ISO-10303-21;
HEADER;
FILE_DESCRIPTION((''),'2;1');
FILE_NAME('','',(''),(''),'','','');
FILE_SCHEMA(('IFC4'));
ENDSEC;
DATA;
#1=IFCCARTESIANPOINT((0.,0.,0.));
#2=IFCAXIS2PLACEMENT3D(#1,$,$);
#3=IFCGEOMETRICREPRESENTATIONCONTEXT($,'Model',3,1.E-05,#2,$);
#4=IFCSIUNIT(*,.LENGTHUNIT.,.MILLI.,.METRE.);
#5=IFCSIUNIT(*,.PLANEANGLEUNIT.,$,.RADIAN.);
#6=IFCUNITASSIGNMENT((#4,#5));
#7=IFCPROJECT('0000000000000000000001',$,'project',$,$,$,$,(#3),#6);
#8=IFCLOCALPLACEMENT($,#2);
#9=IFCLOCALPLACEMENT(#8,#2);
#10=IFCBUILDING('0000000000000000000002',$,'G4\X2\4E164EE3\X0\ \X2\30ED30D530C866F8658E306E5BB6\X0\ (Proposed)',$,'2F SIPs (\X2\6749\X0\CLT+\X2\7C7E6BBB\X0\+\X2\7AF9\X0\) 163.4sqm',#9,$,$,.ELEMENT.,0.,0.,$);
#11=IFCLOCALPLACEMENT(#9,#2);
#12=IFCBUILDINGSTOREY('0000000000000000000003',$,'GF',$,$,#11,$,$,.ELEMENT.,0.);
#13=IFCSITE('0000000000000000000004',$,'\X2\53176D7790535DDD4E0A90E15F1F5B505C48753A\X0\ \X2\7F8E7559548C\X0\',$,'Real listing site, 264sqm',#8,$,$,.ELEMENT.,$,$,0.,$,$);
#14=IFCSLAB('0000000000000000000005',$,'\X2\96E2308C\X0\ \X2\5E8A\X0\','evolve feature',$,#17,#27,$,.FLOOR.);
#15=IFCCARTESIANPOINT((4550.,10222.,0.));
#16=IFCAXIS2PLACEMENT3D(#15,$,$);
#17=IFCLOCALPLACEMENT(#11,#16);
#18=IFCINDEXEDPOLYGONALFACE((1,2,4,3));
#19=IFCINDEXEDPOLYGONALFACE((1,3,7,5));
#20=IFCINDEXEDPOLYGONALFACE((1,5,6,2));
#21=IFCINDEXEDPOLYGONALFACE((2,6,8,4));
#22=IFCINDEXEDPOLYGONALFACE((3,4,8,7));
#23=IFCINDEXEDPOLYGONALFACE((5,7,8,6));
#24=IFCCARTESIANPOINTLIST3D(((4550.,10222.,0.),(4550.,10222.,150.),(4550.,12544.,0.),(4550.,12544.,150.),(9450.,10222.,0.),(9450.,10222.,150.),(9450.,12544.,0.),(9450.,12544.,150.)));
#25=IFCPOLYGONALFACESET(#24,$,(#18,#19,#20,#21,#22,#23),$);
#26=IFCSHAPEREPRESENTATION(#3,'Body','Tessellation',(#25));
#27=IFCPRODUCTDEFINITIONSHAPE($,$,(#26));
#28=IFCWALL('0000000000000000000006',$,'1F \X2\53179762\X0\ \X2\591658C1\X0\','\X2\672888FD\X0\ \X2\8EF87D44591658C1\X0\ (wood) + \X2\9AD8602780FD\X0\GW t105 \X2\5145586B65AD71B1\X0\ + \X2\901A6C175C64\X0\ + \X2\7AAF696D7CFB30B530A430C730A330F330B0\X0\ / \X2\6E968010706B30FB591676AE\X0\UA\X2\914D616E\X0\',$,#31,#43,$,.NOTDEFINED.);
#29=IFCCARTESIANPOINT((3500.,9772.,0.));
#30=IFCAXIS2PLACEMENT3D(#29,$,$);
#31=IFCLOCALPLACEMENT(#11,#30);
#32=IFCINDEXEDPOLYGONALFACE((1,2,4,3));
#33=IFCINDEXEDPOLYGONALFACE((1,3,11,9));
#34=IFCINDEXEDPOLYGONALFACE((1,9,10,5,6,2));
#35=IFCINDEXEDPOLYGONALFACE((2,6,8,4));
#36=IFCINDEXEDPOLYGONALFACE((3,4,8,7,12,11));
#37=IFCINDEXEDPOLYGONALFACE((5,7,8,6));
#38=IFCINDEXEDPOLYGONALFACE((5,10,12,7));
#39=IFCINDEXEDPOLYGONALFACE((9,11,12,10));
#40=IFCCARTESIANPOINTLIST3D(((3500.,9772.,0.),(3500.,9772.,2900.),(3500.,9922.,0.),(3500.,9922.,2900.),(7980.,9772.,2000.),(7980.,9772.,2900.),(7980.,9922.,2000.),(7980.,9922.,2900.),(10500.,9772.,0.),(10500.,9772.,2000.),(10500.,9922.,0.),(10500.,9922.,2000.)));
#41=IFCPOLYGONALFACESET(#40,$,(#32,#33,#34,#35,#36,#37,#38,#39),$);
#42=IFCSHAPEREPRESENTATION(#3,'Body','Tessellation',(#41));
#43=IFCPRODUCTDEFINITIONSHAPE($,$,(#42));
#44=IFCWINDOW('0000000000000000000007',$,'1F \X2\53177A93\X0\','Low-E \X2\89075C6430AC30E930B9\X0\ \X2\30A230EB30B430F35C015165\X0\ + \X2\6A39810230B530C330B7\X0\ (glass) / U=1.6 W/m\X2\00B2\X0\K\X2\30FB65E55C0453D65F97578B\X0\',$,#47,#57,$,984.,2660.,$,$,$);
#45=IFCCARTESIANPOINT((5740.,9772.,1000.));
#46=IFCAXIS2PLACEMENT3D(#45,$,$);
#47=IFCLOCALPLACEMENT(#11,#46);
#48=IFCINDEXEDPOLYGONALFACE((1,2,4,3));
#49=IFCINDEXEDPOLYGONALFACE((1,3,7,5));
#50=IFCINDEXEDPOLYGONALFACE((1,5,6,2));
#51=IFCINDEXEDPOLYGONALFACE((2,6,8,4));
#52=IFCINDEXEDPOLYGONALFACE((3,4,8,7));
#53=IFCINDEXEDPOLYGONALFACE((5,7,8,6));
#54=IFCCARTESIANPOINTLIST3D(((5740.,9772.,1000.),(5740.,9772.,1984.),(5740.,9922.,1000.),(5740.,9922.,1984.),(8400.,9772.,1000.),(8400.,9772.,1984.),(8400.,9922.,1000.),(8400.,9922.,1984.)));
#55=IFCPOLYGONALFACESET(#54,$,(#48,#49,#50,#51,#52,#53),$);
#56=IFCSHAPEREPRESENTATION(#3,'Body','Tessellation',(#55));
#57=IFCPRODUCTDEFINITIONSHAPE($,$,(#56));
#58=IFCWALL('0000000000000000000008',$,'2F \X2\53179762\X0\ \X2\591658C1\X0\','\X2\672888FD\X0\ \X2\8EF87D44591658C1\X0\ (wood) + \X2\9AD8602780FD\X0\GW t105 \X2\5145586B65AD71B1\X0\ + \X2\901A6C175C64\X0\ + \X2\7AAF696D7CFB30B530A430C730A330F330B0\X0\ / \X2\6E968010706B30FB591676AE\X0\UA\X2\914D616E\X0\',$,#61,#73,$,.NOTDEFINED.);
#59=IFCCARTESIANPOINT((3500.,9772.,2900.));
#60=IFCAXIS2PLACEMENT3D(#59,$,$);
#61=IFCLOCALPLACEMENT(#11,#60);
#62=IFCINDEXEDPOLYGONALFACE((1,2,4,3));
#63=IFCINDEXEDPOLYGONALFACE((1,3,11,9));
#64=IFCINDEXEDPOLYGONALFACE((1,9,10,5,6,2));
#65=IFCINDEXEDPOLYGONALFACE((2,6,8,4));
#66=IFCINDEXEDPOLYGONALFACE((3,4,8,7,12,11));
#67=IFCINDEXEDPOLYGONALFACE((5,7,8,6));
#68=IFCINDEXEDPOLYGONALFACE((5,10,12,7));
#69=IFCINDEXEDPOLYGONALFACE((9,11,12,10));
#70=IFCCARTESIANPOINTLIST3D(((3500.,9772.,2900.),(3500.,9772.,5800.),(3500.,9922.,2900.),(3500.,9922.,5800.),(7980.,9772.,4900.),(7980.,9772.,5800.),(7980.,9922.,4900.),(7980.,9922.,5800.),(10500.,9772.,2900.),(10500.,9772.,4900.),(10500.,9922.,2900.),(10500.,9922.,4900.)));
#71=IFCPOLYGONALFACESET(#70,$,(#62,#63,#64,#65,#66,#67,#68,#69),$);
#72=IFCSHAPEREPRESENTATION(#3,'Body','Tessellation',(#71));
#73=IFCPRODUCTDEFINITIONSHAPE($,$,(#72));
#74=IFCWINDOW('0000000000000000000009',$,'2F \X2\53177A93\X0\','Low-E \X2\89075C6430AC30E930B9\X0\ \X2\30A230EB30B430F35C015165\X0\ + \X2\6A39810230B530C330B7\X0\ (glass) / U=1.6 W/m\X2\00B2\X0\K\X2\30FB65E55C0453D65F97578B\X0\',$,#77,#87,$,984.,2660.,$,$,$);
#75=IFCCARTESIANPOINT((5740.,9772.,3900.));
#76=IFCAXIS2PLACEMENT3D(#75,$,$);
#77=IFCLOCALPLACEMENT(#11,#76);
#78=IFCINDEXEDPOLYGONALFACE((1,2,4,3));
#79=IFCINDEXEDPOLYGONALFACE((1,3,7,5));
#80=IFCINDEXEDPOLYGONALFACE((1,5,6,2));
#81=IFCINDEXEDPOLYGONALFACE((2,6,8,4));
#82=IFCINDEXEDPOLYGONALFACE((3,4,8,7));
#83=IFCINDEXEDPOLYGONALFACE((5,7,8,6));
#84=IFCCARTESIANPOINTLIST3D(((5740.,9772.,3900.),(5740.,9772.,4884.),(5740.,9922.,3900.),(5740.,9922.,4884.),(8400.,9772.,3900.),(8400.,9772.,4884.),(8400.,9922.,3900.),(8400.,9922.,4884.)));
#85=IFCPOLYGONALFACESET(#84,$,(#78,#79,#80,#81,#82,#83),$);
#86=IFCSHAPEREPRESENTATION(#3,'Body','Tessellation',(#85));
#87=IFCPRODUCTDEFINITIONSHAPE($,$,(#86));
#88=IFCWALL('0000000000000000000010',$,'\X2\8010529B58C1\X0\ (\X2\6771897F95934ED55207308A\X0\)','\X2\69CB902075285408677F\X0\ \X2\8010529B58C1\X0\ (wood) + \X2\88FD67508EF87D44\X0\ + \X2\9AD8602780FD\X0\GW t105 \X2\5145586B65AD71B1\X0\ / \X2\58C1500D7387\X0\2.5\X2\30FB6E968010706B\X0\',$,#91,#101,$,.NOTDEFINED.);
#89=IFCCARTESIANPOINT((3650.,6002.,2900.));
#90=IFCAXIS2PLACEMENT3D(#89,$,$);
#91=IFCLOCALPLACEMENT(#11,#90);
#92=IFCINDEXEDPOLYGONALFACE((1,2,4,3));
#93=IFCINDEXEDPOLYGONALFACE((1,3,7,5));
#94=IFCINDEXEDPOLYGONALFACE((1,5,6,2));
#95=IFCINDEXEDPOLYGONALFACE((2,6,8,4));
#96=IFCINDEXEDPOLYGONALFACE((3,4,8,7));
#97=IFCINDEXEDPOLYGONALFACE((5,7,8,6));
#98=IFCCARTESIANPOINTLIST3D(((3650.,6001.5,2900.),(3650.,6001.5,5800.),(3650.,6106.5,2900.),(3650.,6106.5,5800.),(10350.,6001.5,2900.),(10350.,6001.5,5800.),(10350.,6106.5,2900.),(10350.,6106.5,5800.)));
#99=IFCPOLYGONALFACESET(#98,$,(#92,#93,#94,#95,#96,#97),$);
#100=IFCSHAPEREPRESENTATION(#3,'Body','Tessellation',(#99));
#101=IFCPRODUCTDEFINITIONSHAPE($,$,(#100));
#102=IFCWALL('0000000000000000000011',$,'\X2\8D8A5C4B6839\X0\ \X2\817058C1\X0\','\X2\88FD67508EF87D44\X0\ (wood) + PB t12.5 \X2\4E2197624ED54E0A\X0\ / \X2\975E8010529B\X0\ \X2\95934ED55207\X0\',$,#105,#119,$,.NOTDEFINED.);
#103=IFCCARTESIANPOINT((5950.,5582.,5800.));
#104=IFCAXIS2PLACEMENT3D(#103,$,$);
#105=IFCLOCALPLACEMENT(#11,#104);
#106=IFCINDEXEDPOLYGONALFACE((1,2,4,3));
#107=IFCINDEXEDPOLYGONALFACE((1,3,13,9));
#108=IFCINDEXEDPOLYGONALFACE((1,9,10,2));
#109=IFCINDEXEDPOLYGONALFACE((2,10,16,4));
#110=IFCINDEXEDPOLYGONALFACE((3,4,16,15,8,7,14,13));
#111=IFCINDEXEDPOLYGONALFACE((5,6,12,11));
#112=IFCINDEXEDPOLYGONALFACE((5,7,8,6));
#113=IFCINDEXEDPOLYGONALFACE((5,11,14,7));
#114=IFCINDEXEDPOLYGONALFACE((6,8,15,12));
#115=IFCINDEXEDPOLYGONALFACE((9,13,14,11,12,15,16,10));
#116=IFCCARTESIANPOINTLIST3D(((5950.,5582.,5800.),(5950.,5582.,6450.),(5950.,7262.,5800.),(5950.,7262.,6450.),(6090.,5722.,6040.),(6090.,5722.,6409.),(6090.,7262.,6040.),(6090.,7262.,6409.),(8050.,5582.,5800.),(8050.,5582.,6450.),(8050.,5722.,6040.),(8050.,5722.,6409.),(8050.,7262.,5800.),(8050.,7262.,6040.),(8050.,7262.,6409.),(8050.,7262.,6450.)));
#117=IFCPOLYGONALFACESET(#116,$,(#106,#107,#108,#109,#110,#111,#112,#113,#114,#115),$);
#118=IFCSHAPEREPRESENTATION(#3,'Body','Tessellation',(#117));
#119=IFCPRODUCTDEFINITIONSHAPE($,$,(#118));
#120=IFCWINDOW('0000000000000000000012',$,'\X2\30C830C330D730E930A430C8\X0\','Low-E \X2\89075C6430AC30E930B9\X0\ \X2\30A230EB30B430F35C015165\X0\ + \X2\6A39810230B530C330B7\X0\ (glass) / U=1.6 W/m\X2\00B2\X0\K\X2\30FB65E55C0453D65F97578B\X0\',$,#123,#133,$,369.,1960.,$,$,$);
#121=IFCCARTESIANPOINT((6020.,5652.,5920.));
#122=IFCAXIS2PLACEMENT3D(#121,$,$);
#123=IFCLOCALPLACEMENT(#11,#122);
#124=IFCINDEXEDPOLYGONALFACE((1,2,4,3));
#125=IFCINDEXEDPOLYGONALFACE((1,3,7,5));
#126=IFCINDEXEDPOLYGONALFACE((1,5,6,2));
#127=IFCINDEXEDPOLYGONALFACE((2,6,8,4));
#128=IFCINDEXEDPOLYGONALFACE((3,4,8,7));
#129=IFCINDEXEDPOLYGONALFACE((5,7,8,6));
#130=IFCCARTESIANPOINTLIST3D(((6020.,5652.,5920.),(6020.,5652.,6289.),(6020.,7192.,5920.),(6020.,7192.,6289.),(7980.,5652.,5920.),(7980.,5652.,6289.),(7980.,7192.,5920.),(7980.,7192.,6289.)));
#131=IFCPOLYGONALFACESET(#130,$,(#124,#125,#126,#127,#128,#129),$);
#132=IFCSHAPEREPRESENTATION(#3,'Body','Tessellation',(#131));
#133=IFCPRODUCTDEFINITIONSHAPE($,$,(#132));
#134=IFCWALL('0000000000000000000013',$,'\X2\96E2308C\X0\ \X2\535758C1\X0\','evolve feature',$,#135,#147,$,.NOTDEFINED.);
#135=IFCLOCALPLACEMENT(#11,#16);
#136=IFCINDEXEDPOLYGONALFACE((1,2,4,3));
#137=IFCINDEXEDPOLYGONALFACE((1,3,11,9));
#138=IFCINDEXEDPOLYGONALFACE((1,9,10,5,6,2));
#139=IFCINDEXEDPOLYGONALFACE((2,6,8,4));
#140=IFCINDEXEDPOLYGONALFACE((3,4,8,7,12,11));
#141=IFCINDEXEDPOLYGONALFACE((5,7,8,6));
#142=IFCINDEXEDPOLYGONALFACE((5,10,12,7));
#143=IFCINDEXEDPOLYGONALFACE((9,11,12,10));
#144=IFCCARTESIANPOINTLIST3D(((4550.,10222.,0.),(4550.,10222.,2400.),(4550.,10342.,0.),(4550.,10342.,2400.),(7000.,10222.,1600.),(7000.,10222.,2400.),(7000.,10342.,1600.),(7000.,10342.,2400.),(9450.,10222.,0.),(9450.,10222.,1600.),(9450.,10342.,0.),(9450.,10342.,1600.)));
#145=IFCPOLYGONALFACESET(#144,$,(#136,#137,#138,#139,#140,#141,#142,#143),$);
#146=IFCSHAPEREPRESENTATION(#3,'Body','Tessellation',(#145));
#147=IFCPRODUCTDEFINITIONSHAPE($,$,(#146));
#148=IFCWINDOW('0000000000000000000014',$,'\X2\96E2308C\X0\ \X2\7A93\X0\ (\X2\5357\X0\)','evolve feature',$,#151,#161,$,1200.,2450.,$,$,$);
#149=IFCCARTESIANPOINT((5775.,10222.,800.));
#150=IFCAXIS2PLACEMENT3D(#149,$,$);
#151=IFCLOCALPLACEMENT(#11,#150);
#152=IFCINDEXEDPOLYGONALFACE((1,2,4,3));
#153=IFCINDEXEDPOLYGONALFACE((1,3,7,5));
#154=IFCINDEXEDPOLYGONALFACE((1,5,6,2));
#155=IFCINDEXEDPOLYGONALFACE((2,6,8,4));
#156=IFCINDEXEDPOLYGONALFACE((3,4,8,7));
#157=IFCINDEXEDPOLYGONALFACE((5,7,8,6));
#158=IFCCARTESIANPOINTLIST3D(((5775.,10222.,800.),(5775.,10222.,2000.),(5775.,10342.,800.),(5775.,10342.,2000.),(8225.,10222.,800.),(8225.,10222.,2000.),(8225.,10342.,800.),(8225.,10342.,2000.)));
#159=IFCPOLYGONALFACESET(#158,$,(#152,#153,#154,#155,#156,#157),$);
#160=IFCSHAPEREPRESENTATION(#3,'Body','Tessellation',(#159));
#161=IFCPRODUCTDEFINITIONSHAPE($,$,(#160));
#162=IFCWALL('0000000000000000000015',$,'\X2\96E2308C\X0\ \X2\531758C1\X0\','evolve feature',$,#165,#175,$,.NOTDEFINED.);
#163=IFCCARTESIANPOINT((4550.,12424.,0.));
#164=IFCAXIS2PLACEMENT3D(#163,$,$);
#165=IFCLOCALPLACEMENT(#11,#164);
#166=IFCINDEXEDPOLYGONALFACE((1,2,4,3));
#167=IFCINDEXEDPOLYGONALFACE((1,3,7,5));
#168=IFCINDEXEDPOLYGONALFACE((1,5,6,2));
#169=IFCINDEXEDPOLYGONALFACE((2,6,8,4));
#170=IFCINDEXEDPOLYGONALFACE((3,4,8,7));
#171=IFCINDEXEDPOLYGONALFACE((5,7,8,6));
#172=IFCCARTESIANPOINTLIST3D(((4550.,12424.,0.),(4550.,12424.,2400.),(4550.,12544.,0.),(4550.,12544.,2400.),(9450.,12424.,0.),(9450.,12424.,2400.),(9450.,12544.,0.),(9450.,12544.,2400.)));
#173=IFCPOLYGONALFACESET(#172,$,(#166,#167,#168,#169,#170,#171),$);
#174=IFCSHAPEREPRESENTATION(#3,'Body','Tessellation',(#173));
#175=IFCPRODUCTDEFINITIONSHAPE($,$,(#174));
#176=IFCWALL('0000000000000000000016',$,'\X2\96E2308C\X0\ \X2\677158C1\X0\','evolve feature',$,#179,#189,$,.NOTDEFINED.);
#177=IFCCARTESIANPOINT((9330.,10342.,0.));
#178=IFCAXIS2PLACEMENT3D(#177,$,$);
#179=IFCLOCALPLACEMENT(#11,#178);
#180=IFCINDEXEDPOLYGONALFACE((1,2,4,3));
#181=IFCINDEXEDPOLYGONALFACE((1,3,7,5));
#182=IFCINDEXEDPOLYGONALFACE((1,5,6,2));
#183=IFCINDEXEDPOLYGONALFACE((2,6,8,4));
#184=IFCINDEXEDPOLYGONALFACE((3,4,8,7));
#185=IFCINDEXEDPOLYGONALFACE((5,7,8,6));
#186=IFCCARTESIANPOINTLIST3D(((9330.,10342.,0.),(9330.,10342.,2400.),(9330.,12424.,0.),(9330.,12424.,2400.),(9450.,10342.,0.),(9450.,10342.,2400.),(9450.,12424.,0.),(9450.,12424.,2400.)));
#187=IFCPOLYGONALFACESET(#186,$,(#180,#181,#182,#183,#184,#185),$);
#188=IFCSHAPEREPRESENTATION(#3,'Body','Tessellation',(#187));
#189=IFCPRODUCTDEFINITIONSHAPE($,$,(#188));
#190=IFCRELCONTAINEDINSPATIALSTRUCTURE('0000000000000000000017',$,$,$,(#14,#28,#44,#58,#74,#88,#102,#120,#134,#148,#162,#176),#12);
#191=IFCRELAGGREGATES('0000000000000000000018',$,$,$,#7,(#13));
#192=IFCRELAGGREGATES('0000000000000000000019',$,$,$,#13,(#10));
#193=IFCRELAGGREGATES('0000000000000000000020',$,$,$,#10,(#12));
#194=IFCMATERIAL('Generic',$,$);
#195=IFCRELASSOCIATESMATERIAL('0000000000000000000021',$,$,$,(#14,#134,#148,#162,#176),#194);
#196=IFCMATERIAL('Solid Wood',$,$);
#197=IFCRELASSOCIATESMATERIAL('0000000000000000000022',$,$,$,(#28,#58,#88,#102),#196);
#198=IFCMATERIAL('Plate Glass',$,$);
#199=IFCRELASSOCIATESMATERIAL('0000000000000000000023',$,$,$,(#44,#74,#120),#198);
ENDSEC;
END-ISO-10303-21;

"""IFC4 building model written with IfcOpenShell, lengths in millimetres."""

from ifc_helpers import new_model, si_unit, frame, frame_2d, origin, place, context, project, spatial, rectangle, extrude, material, element, fill, save


model = new_model("IFC4")

# Units and contexts
model_context = context("Model", 3, precision=1e-05, world=origin())
ifc_project = project(units=[si_unit("LENGTHUNIT", "METRE", prefix="MILLI"), si_unit("PLANEANGLEUNIT", "RADIAN")], contexts=[model_context])

# Site, building, storey
site_placement = place(None, origin())
site = spatial("IfcSite", under=ifc_project, at=site_placement, Name="北海道川上郡弟子屈町 美留和", ObjectType="Real listing site, 264sqm", CompositionType="ELEMENT", RefElevation=0.0)
building_placement = place(site_placement, origin())
building = spatial("IfcBuilding", under=site, at=building_placement, Name="G4世代 ロフト書斎の家 (Proposed)", ObjectType="2F SIPs (杉CLT+籾殻+竹) 163.4sqm", CompositionType="ELEMENT", ElevationOfRefHeight=0.0, ElevationOfTerrain=0.0)
storey_placement = place(building_placement, origin())
storey = spatial("IfcBuildingStorey", under=building, at=storey_placement, Name="GF", CompositionType="ELEMENT", Elevation=0.0)

# Slab
ifc_material_1 = material(Name="Generic")
slab_placement = place(storey_placement, frame((4550.0, 10222.0, 0.0)))
element("IfcSlab", 1, at=slab_placement, inside=storey, material=ifc_material_1, Name="離れ 床", Description="evolve feature", PredefinedType="FLOOR", context=model_context, shape_type="SweptSolid", body=[
    extrude(rectangle(XDim=4900.0, YDim=2322.0, at=frame_2d((2450.0, 1161.0))), frame((4550.0, 10222.0, 0.0)), (0.0, 0.0, 1.0), 150.0),
])

# Wall, opening, window
ifc_material_2 = material(Name="Solid Wood")
wall_1_placement = place(storey_placement, frame((3500.0, 9772.0, 0.0)))
wall_1 = element("IfcWall", 2, at=wall_1_placement, inside=storey, material=ifc_material_2, Name="1F 北面 外壁", Description="木製 軸組外壁 (wood) + 高性能GW t105 充填断熱 + 通気層 + 窯業系サイディング / 準耐火・外皮UA配慮", PredefinedType="NOTDEFINED", context=model_context, shape_type="SweptSolid", body=[
    extrude(rectangle(XDim=7000.0, YDim=150.0, at=frame_2d((3500.0, 75.0))), frame((3500.0, 9772.0, 0.0)), (0.0, 0.0, 1.0), 2900.0),
])
opening_1_placement = place(storey_placement, frame((5740.0, 9772.0, 1000.0)))
opening_1 = element("IfcOpeningElement", 3, at=opening_1_placement, cuts=wall_1, PredefinedType="NOTDEFINED", context=model_context, shape_type="SweptSolid", body=[
    extrude(rectangle(XDim=2660.0, YDim=150.0, at=frame_2d((1330.0, 75.0))), frame((5740.0, 9772.0, 1000.0)), (0.0, 0.0, 1.0), 984.0),
])
ifc_material_3 = material(Name="Plate Glass")
window_1_placement = place(storey_placement, frame((5740.0, 9772.0, 1000.0)))
window_1 = element("IfcWindow", 4, at=window_1_placement, inside=storey, material=ifc_material_3, Name="1F 北窓", Description="Low-E 複層ガラス アルゴン封入 + 樹脂サッシ (glass) / U=1.6 W/m²K・日射取得型", OverallHeight=984.0, OverallWidth=2660.0, context=model_context, shape_type="SweptSolid", body=[
    extrude(rectangle(XDim=2660.0, YDim=150.0, at=frame_2d((1330.0, 75.0))), frame((5740.0, 9772.0, 1000.0)), (0.0, 0.0, 1.0), 984.0),
])
fill(opening_1, window_1)

# Wall, opening, window
wall_2_placement = place(storey_placement, frame((3500.0, 9772.0, 2900.0)))
wall_2 = element("IfcWall", 5, at=wall_2_placement, inside=storey, material=ifc_material_2, Name="2F 北面 外壁", Description="木製 軸組外壁 (wood) + 高性能GW t105 充填断熱 + 通気層 + 窯業系サイディング / 準耐火・外皮UA配慮", PredefinedType="NOTDEFINED", context=model_context, shape_type="SweptSolid", body=[
    extrude(rectangle(XDim=7000.0, YDim=150.0, at=frame_2d((3500.0, 75.0))), frame((3500.0, 9772.0, 2900.0)), (0.0, 0.0, 1.0), 2900.0),
])
opening_2_placement = place(storey_placement, frame((5740.0, 9772.0, 3900.0)))
opening_2 = element("IfcOpeningElement", 6, at=opening_2_placement, cuts=wall_2, PredefinedType="NOTDEFINED", context=model_context, shape_type="SweptSolid", body=[
    extrude(rectangle(XDim=2660.0, YDim=150.0, at=frame_2d((1330.0, 75.0))), frame((5740.0, 9772.0, 3900.0)), (0.0, 0.0, 1.0), 984.0),
])
window_2_placement = place(storey_placement, frame((5740.0, 9772.0, 3900.0)))
window_2 = element("IfcWindow", 7, at=window_2_placement, inside=storey, material=ifc_material_3, Name="2F 北窓", Description="Low-E 複層ガラス アルゴン封入 + 樹脂サッシ (glass) / U=1.6 W/m²K・日射取得型", OverallHeight=984.0, OverallWidth=2660.0, context=model_context, shape_type="SweptSolid", body=[
    extrude(rectangle(XDim=2660.0, YDim=150.0, at=frame_2d((1330.0, 75.0))), frame((5740.0, 9772.0, 3900.0)), (0.0, 0.0, 1.0), 984.0),
])
fill(opening_2, window_2)

# Wall
wall_3_placement = place(storey_placement, frame((3650.0, 6002.0, 2900.0)))
element("IfcWall", 8, at=wall_3_placement, inside=storey, material=ifc_material_2, Name="耐力壁 (東西間仕切り)", Description="構造用合板 耐力壁 (wood) + 製材軸組 + 高性能GW t105 充填断熱 / 壁倍率2.5・準耐火", PredefinedType="NOTDEFINED", context=model_context, shape_type="SweptSolid", body=[
    extrude(rectangle(XDim=6700.0, YDim=105.0, at=frame_2d((3350.0, 52.0))), frame((3650.0, 6002.0, 2900.0)), (0.0, 0.0, 1.0), 2900.0),
])

# Walls, openings, windows
wall_4_placement = place(storey_placement, frame((5950.0, 5582.0, 5800.0)))
wall_4 = element("IfcWall", 9, at=wall_4_placement, inside=storey, material=ifc_material_2, Name="越屋根 腰壁", Description="製材軸組 (wood) + PB t12.5 両面仕上 / 非耐力 間仕切", PredefinedType="NOTDEFINED", context=model_context, shape_type="SweptSolid", body=[
    extrude(rectangle(XDim=2100.0, YDim=1680.0, at=frame_2d((1050.0, 840.0))), frame((5950.0, 5582.0, 5800.0)), (0.0, 0.0, 1.0), 650.0),
])
opening_3_placement = place(storey_placement, frame((6020.0, 5652.0, 5920.0)))
opening_3 = element("IfcOpeningElement", 10, at=opening_3_placement, cuts=wall_4, PredefinedType="NOTDEFINED", context=model_context, shape_type="SweptSolid", body=[
    extrude(rectangle(XDim=1960.0, YDim=1540.0, at=frame_2d((980.0, 770.0))), frame((6020.0, 5652.0, 5920.0)), (0.0, 0.0, 1.0), 369.0),
])
window_3_placement = place(storey_placement, frame((6020.0, 5652.0, 5920.0)))
window_3 = element("IfcWindow", 11, at=window_3_placement, inside=storey, material=ifc_material_3, Name="トップライト", Description="Low-E 複層ガラス アルゴン封入 + 樹脂サッシ (glass) / U=1.6 W/m²K・日射取得型", OverallHeight=369.0, OverallWidth=1960.0, context=model_context, shape_type="SweptSolid", body=[
    extrude(rectangle(XDim=1960.0, YDim=1540.0, at=frame_2d((980.0, 770.0))), frame((6020.0, 5652.0, 5920.0)), (0.0, 0.0, 1.0), 369.0),
])
fill(opening_3, window_3)
wall_5_placement = place(storey_placement, frame((4550.0, 10222.0, 0.0)))
wall_5 = element("IfcWall", 12, at=wall_5_placement, inside=storey, material=ifc_material_1, Name="離れ 南壁", Description="evolve feature", PredefinedType="NOTDEFINED", context=model_context, shape_type="SweptSolid", body=[
    extrude(rectangle(XDim=4900.0, YDim=120.0, at=frame_2d((2450.0, 60.0))), frame((4550.0, 10222.0, 0.0)), (0.0, 0.0, 1.0), 2400.0),
])
opening_4_placement = place(storey_placement, frame((5775.0, 10222.0, 800.0)))
opening_4 = element("IfcOpeningElement", 13, at=opening_4_placement, cuts=wall_5, PredefinedType="NOTDEFINED", context=model_context, shape_type="SweptSolid", body=[
    extrude(rectangle(XDim=2450.0, YDim=120.0, at=frame_2d((1225.0, 60.0))), frame((5775.0, 10222.0, 800.0)), (0.0, 0.0, 1.0), 1200.0),
])
window_4_placement = place(storey_placement, frame((5775.0, 10222.0, 800.0)))
window_4 = element("IfcWindow", 14, at=window_4_placement, inside=storey, material=ifc_material_1, Name="離れ 窓 (南)", Description="evolve feature", OverallHeight=1200.0, OverallWidth=2450.0, context=model_context, shape_type="SweptSolid", body=[
    extrude(rectangle(XDim=2450.0, YDim=120.0, at=frame_2d((1225.0, 60.0))), frame((5775.0, 10222.0, 800.0)), (0.0, 0.0, 1.0), 1200.0),
])
fill(opening_4, window_4)

# Walls
wall_6_placement = place(storey_placement, frame((4550.0, 12424.0, 0.0)))
element("IfcWall", 15, at=wall_6_placement, inside=storey, material=ifc_material_1, Name="離れ 北壁", Description="evolve feature", PredefinedType="NOTDEFINED", context=model_context, shape_type="SweptSolid", body=[
    extrude(rectangle(XDim=4900.0, YDim=120.0, at=frame_2d((2450.0, 60.0))), frame((4550.0, 12424.0, 0.0)), (0.0, 0.0, 1.0), 2400.0),
])
wall_7_placement = place(storey_placement, frame((9330.0, 10342.0, 0.0)))
element("IfcWall", 16, at=wall_7_placement, inside=storey, material=ifc_material_1, Name="離れ 東壁", Description="evolve feature", PredefinedType="NOTDEFINED", context=model_context, shape_type="SweptSolid", body=[
    extrude(rectangle(XDim=120.0, YDim=2082.0, at=frame_2d((60.0, 1041.0))), frame((9330.0, 10342.0, 0.0)), (0.0, 0.0, 1.0), 2400.0),
])

save(model, "model.ifc")
